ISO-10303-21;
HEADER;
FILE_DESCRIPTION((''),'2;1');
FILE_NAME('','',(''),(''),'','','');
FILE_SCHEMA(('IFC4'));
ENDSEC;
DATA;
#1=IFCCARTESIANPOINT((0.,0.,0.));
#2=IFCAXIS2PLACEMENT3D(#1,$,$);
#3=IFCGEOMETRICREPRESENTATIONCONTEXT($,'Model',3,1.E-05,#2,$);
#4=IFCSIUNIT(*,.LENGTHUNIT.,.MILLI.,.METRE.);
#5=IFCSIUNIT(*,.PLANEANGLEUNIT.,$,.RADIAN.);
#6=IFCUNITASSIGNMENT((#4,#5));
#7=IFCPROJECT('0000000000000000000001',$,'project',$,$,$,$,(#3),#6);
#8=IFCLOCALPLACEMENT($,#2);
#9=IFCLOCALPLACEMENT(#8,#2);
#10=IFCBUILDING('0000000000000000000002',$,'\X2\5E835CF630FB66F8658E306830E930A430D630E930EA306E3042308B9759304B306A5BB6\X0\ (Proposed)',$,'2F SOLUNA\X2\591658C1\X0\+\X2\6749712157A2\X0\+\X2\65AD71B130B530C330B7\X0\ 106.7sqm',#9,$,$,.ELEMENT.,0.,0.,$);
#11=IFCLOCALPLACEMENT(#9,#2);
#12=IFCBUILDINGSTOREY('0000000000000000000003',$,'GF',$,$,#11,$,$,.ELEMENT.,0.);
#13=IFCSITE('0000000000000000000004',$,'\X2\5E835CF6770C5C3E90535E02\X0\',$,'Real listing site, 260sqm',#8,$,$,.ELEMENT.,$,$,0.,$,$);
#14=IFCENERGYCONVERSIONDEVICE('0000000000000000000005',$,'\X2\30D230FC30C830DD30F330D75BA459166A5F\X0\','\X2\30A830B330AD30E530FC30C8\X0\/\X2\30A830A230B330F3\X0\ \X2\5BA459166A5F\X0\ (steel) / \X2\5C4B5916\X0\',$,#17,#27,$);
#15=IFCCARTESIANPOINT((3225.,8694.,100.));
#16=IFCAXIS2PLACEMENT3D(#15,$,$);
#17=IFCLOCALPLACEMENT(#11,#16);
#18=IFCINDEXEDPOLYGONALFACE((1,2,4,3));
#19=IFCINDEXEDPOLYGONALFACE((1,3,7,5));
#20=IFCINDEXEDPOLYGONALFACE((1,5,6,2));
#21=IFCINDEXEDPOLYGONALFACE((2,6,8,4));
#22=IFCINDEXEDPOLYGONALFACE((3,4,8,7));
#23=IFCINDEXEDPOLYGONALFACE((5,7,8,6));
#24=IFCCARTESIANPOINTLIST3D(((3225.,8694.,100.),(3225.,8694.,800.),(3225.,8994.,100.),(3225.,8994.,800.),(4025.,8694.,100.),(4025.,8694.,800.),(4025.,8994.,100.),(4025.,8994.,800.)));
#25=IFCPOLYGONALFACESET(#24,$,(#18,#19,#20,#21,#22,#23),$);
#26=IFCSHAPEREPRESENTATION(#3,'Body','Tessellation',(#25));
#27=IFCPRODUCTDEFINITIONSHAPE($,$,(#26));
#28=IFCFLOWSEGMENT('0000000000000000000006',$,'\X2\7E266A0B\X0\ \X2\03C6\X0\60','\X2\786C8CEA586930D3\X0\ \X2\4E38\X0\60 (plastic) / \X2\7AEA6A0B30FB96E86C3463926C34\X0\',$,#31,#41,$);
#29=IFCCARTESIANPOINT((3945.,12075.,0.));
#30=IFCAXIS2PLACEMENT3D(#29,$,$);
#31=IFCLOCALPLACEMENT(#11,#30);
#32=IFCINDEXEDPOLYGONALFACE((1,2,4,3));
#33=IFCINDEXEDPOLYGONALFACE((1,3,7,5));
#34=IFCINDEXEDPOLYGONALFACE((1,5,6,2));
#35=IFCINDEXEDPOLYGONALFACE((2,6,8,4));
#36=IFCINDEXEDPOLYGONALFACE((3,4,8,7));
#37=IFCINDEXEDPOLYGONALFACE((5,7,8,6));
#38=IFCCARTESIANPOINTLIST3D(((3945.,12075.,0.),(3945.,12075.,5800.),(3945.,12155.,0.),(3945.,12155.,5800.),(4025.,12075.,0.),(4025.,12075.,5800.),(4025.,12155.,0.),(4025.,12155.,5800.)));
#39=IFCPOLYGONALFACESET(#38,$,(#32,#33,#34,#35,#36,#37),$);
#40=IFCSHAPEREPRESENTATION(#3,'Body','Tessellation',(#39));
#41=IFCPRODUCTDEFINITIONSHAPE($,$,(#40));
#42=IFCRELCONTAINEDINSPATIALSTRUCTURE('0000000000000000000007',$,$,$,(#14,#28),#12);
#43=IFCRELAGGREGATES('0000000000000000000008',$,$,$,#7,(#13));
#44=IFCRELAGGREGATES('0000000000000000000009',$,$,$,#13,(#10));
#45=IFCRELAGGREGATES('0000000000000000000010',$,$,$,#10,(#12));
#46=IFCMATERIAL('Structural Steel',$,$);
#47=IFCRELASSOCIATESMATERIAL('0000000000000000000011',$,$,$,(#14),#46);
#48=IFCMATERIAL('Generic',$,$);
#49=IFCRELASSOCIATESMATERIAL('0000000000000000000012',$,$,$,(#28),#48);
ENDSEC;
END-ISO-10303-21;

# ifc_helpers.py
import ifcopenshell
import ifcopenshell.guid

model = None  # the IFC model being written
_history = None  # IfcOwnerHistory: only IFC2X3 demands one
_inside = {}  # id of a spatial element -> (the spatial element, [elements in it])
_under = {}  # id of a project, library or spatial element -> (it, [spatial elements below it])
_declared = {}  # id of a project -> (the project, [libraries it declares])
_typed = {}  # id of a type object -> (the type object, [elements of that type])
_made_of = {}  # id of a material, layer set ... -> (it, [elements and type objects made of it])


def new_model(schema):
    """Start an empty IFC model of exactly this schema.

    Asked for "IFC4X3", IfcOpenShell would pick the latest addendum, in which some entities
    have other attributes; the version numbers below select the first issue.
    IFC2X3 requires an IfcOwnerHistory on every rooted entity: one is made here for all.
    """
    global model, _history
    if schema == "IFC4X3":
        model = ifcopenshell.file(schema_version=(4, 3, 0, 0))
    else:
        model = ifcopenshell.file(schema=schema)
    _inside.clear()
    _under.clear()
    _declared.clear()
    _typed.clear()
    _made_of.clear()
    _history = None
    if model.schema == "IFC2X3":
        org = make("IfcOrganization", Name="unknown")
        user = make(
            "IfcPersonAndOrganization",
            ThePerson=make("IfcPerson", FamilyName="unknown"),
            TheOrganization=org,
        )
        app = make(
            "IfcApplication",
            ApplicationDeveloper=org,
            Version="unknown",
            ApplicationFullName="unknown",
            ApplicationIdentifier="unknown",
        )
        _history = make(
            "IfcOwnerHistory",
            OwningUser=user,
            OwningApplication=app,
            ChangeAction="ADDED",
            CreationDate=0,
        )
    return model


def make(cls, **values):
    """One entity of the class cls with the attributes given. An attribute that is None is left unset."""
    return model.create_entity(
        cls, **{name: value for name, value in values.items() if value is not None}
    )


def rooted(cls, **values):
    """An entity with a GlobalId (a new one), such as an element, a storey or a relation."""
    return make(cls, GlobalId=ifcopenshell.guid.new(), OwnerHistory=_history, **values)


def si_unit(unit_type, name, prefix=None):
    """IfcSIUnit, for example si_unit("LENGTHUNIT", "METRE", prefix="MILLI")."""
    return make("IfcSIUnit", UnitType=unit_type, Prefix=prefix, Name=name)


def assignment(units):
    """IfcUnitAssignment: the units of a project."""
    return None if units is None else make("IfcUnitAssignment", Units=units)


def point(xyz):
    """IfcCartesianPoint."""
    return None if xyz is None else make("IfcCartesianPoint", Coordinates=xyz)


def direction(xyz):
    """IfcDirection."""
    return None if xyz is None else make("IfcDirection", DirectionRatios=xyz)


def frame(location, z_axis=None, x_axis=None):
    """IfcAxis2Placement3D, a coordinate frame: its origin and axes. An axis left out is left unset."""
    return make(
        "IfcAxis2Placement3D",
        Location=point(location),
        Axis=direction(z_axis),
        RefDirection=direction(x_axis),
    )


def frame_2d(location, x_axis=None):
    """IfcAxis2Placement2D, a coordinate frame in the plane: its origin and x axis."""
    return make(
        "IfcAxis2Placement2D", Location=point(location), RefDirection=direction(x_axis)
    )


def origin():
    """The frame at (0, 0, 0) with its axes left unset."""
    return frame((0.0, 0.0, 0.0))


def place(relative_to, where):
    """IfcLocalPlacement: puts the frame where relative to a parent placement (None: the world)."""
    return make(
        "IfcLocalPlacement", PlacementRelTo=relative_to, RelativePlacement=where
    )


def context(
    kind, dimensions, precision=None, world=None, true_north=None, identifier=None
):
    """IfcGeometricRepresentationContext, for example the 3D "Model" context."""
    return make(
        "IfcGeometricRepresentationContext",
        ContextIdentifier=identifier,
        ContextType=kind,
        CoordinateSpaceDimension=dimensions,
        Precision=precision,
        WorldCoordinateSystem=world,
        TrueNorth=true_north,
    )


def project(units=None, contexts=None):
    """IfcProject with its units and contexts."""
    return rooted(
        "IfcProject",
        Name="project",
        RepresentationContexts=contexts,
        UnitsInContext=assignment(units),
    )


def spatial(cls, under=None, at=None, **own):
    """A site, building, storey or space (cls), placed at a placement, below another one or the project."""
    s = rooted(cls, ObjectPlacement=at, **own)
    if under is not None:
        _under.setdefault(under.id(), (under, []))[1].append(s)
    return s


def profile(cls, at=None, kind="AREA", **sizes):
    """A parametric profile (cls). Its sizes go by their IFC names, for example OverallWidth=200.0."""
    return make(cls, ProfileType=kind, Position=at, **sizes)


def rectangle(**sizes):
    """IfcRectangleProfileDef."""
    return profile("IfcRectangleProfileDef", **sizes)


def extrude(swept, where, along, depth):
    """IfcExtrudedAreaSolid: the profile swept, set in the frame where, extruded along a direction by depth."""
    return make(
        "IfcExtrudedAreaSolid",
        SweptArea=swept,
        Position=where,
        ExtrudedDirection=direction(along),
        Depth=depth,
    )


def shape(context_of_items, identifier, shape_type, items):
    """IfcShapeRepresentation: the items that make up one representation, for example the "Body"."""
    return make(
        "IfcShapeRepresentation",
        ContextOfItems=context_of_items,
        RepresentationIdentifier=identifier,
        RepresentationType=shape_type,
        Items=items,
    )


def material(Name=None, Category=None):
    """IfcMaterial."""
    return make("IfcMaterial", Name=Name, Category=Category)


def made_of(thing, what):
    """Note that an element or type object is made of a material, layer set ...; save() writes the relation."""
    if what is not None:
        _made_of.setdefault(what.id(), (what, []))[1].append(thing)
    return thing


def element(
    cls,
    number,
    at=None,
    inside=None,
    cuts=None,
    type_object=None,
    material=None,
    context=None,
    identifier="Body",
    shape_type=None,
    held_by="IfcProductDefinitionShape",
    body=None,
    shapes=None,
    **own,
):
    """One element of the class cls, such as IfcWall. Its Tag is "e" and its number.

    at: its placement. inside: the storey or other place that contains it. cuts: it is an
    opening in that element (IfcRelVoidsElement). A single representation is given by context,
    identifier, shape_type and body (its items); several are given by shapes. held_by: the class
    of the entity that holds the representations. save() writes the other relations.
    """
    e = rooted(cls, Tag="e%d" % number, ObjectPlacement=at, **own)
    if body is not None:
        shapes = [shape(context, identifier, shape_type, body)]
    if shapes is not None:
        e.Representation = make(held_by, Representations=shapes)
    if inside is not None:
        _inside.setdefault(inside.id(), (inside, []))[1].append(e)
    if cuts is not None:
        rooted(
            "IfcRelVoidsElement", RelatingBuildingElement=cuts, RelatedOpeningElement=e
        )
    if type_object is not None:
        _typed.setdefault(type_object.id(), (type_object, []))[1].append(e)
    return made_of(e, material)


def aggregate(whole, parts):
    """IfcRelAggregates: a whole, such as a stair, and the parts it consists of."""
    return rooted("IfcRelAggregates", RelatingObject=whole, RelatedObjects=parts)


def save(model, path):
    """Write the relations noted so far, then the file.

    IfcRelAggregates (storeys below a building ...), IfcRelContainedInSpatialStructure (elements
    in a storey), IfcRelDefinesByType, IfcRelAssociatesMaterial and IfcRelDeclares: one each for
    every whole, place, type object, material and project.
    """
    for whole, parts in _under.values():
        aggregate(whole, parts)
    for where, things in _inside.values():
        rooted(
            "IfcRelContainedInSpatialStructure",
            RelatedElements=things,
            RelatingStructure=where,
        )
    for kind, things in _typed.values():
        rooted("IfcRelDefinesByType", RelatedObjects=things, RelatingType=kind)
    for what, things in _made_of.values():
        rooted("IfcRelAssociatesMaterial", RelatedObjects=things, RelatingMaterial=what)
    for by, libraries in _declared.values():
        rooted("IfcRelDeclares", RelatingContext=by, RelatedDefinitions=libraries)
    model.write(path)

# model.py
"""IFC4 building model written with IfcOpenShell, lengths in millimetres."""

from ifc_helpers import new_model, si_unit, frame, frame_2d, origin, place, context, project, spatial, rectangle, extrude, material, element, save


model = new_model("IFC4")

# Units and contexts
model_context = context("Model", 3, precision=1e-05, world=origin())
ifc_project = project(units=[si_unit("LENGTHUNIT", "METRE", prefix="MILLI"), si_unit("PLANEANGLEUNIT", "RADIAN")], contexts=[model_context])

# Site, building, storey
site_placement = place(None, origin())
site = spatial("IfcSite", under=ifc_project, at=site_placement, Name="広島県尾道市", ObjectType="Real listing site, 260sqm", CompositionType="ELEMENT", RefElevation=0.0)
building_placement = place(site_placement, origin())
building = spatial("IfcBuilding", under=site, at=building_placement, Name="広島・書斎とライブラリのある静かな家 (Proposed)", ObjectType="2F SOLUNA外壁+杉無垢+断熱サッシ 106.7sqm", CompositionType="ELEMENT", ElevationOfRefHeight=0.0, ElevationOfTerrain=0.0)
storey_placement = place(building_placement, origin())
storey = spatial("IfcBuildingStorey", under=building, at=storey_placement, Name="GF", CompositionType="ELEMENT", Elevation=0.0)

# Shared definitions
ifc_material_1 = material(Name="Generic")

# Energy conversion device
ifc_material_2 = material(Name="Structural Steel")
energy_conversion_device_placement = place(storey_placement, frame((3225.0, 8694.0, 100.0)))
element("IfcEnergyConversionDevice", 1, at=energy_conversion_device_placement, inside=storey, material=ifc_material_2, Name="ヒートポンプ室外機", Description="エコキュート/エアコン 室外機 (steel) / 屋外", context=model_context, shape_type="SweptSolid", body=[
    extrude(rectangle(XDim=800.0, YDim=300.0, at=frame_2d((400.0, 150.0))), frame((3225.0, 8694.0, 100.0)), (0.0, 0.0, 1.0), 700.0),
])

# Flow segment
flow_segment_placement = place(storey_placement, frame((3945.0, 12075.0, 0.0)))
element("IfcFlowSegment", 2, at=flow_segment_placement, inside=storey, material=ifc_material_1, Name="縦樋 φ60", Description="硬質塩ビ 丸60 (plastic) / 竪樋・雨水排水", context=model_context, shape_type="SweptSolid", body=[
    extrude(rectangle(XDim=80.0, YDim=80.0, at=frame_2d((40.0, 40.0))), frame((3945.0, 12075.0, 0.0)), (0.0, 0.0, 1.0), 5800.0),
])

save(model, "model.ifc")
